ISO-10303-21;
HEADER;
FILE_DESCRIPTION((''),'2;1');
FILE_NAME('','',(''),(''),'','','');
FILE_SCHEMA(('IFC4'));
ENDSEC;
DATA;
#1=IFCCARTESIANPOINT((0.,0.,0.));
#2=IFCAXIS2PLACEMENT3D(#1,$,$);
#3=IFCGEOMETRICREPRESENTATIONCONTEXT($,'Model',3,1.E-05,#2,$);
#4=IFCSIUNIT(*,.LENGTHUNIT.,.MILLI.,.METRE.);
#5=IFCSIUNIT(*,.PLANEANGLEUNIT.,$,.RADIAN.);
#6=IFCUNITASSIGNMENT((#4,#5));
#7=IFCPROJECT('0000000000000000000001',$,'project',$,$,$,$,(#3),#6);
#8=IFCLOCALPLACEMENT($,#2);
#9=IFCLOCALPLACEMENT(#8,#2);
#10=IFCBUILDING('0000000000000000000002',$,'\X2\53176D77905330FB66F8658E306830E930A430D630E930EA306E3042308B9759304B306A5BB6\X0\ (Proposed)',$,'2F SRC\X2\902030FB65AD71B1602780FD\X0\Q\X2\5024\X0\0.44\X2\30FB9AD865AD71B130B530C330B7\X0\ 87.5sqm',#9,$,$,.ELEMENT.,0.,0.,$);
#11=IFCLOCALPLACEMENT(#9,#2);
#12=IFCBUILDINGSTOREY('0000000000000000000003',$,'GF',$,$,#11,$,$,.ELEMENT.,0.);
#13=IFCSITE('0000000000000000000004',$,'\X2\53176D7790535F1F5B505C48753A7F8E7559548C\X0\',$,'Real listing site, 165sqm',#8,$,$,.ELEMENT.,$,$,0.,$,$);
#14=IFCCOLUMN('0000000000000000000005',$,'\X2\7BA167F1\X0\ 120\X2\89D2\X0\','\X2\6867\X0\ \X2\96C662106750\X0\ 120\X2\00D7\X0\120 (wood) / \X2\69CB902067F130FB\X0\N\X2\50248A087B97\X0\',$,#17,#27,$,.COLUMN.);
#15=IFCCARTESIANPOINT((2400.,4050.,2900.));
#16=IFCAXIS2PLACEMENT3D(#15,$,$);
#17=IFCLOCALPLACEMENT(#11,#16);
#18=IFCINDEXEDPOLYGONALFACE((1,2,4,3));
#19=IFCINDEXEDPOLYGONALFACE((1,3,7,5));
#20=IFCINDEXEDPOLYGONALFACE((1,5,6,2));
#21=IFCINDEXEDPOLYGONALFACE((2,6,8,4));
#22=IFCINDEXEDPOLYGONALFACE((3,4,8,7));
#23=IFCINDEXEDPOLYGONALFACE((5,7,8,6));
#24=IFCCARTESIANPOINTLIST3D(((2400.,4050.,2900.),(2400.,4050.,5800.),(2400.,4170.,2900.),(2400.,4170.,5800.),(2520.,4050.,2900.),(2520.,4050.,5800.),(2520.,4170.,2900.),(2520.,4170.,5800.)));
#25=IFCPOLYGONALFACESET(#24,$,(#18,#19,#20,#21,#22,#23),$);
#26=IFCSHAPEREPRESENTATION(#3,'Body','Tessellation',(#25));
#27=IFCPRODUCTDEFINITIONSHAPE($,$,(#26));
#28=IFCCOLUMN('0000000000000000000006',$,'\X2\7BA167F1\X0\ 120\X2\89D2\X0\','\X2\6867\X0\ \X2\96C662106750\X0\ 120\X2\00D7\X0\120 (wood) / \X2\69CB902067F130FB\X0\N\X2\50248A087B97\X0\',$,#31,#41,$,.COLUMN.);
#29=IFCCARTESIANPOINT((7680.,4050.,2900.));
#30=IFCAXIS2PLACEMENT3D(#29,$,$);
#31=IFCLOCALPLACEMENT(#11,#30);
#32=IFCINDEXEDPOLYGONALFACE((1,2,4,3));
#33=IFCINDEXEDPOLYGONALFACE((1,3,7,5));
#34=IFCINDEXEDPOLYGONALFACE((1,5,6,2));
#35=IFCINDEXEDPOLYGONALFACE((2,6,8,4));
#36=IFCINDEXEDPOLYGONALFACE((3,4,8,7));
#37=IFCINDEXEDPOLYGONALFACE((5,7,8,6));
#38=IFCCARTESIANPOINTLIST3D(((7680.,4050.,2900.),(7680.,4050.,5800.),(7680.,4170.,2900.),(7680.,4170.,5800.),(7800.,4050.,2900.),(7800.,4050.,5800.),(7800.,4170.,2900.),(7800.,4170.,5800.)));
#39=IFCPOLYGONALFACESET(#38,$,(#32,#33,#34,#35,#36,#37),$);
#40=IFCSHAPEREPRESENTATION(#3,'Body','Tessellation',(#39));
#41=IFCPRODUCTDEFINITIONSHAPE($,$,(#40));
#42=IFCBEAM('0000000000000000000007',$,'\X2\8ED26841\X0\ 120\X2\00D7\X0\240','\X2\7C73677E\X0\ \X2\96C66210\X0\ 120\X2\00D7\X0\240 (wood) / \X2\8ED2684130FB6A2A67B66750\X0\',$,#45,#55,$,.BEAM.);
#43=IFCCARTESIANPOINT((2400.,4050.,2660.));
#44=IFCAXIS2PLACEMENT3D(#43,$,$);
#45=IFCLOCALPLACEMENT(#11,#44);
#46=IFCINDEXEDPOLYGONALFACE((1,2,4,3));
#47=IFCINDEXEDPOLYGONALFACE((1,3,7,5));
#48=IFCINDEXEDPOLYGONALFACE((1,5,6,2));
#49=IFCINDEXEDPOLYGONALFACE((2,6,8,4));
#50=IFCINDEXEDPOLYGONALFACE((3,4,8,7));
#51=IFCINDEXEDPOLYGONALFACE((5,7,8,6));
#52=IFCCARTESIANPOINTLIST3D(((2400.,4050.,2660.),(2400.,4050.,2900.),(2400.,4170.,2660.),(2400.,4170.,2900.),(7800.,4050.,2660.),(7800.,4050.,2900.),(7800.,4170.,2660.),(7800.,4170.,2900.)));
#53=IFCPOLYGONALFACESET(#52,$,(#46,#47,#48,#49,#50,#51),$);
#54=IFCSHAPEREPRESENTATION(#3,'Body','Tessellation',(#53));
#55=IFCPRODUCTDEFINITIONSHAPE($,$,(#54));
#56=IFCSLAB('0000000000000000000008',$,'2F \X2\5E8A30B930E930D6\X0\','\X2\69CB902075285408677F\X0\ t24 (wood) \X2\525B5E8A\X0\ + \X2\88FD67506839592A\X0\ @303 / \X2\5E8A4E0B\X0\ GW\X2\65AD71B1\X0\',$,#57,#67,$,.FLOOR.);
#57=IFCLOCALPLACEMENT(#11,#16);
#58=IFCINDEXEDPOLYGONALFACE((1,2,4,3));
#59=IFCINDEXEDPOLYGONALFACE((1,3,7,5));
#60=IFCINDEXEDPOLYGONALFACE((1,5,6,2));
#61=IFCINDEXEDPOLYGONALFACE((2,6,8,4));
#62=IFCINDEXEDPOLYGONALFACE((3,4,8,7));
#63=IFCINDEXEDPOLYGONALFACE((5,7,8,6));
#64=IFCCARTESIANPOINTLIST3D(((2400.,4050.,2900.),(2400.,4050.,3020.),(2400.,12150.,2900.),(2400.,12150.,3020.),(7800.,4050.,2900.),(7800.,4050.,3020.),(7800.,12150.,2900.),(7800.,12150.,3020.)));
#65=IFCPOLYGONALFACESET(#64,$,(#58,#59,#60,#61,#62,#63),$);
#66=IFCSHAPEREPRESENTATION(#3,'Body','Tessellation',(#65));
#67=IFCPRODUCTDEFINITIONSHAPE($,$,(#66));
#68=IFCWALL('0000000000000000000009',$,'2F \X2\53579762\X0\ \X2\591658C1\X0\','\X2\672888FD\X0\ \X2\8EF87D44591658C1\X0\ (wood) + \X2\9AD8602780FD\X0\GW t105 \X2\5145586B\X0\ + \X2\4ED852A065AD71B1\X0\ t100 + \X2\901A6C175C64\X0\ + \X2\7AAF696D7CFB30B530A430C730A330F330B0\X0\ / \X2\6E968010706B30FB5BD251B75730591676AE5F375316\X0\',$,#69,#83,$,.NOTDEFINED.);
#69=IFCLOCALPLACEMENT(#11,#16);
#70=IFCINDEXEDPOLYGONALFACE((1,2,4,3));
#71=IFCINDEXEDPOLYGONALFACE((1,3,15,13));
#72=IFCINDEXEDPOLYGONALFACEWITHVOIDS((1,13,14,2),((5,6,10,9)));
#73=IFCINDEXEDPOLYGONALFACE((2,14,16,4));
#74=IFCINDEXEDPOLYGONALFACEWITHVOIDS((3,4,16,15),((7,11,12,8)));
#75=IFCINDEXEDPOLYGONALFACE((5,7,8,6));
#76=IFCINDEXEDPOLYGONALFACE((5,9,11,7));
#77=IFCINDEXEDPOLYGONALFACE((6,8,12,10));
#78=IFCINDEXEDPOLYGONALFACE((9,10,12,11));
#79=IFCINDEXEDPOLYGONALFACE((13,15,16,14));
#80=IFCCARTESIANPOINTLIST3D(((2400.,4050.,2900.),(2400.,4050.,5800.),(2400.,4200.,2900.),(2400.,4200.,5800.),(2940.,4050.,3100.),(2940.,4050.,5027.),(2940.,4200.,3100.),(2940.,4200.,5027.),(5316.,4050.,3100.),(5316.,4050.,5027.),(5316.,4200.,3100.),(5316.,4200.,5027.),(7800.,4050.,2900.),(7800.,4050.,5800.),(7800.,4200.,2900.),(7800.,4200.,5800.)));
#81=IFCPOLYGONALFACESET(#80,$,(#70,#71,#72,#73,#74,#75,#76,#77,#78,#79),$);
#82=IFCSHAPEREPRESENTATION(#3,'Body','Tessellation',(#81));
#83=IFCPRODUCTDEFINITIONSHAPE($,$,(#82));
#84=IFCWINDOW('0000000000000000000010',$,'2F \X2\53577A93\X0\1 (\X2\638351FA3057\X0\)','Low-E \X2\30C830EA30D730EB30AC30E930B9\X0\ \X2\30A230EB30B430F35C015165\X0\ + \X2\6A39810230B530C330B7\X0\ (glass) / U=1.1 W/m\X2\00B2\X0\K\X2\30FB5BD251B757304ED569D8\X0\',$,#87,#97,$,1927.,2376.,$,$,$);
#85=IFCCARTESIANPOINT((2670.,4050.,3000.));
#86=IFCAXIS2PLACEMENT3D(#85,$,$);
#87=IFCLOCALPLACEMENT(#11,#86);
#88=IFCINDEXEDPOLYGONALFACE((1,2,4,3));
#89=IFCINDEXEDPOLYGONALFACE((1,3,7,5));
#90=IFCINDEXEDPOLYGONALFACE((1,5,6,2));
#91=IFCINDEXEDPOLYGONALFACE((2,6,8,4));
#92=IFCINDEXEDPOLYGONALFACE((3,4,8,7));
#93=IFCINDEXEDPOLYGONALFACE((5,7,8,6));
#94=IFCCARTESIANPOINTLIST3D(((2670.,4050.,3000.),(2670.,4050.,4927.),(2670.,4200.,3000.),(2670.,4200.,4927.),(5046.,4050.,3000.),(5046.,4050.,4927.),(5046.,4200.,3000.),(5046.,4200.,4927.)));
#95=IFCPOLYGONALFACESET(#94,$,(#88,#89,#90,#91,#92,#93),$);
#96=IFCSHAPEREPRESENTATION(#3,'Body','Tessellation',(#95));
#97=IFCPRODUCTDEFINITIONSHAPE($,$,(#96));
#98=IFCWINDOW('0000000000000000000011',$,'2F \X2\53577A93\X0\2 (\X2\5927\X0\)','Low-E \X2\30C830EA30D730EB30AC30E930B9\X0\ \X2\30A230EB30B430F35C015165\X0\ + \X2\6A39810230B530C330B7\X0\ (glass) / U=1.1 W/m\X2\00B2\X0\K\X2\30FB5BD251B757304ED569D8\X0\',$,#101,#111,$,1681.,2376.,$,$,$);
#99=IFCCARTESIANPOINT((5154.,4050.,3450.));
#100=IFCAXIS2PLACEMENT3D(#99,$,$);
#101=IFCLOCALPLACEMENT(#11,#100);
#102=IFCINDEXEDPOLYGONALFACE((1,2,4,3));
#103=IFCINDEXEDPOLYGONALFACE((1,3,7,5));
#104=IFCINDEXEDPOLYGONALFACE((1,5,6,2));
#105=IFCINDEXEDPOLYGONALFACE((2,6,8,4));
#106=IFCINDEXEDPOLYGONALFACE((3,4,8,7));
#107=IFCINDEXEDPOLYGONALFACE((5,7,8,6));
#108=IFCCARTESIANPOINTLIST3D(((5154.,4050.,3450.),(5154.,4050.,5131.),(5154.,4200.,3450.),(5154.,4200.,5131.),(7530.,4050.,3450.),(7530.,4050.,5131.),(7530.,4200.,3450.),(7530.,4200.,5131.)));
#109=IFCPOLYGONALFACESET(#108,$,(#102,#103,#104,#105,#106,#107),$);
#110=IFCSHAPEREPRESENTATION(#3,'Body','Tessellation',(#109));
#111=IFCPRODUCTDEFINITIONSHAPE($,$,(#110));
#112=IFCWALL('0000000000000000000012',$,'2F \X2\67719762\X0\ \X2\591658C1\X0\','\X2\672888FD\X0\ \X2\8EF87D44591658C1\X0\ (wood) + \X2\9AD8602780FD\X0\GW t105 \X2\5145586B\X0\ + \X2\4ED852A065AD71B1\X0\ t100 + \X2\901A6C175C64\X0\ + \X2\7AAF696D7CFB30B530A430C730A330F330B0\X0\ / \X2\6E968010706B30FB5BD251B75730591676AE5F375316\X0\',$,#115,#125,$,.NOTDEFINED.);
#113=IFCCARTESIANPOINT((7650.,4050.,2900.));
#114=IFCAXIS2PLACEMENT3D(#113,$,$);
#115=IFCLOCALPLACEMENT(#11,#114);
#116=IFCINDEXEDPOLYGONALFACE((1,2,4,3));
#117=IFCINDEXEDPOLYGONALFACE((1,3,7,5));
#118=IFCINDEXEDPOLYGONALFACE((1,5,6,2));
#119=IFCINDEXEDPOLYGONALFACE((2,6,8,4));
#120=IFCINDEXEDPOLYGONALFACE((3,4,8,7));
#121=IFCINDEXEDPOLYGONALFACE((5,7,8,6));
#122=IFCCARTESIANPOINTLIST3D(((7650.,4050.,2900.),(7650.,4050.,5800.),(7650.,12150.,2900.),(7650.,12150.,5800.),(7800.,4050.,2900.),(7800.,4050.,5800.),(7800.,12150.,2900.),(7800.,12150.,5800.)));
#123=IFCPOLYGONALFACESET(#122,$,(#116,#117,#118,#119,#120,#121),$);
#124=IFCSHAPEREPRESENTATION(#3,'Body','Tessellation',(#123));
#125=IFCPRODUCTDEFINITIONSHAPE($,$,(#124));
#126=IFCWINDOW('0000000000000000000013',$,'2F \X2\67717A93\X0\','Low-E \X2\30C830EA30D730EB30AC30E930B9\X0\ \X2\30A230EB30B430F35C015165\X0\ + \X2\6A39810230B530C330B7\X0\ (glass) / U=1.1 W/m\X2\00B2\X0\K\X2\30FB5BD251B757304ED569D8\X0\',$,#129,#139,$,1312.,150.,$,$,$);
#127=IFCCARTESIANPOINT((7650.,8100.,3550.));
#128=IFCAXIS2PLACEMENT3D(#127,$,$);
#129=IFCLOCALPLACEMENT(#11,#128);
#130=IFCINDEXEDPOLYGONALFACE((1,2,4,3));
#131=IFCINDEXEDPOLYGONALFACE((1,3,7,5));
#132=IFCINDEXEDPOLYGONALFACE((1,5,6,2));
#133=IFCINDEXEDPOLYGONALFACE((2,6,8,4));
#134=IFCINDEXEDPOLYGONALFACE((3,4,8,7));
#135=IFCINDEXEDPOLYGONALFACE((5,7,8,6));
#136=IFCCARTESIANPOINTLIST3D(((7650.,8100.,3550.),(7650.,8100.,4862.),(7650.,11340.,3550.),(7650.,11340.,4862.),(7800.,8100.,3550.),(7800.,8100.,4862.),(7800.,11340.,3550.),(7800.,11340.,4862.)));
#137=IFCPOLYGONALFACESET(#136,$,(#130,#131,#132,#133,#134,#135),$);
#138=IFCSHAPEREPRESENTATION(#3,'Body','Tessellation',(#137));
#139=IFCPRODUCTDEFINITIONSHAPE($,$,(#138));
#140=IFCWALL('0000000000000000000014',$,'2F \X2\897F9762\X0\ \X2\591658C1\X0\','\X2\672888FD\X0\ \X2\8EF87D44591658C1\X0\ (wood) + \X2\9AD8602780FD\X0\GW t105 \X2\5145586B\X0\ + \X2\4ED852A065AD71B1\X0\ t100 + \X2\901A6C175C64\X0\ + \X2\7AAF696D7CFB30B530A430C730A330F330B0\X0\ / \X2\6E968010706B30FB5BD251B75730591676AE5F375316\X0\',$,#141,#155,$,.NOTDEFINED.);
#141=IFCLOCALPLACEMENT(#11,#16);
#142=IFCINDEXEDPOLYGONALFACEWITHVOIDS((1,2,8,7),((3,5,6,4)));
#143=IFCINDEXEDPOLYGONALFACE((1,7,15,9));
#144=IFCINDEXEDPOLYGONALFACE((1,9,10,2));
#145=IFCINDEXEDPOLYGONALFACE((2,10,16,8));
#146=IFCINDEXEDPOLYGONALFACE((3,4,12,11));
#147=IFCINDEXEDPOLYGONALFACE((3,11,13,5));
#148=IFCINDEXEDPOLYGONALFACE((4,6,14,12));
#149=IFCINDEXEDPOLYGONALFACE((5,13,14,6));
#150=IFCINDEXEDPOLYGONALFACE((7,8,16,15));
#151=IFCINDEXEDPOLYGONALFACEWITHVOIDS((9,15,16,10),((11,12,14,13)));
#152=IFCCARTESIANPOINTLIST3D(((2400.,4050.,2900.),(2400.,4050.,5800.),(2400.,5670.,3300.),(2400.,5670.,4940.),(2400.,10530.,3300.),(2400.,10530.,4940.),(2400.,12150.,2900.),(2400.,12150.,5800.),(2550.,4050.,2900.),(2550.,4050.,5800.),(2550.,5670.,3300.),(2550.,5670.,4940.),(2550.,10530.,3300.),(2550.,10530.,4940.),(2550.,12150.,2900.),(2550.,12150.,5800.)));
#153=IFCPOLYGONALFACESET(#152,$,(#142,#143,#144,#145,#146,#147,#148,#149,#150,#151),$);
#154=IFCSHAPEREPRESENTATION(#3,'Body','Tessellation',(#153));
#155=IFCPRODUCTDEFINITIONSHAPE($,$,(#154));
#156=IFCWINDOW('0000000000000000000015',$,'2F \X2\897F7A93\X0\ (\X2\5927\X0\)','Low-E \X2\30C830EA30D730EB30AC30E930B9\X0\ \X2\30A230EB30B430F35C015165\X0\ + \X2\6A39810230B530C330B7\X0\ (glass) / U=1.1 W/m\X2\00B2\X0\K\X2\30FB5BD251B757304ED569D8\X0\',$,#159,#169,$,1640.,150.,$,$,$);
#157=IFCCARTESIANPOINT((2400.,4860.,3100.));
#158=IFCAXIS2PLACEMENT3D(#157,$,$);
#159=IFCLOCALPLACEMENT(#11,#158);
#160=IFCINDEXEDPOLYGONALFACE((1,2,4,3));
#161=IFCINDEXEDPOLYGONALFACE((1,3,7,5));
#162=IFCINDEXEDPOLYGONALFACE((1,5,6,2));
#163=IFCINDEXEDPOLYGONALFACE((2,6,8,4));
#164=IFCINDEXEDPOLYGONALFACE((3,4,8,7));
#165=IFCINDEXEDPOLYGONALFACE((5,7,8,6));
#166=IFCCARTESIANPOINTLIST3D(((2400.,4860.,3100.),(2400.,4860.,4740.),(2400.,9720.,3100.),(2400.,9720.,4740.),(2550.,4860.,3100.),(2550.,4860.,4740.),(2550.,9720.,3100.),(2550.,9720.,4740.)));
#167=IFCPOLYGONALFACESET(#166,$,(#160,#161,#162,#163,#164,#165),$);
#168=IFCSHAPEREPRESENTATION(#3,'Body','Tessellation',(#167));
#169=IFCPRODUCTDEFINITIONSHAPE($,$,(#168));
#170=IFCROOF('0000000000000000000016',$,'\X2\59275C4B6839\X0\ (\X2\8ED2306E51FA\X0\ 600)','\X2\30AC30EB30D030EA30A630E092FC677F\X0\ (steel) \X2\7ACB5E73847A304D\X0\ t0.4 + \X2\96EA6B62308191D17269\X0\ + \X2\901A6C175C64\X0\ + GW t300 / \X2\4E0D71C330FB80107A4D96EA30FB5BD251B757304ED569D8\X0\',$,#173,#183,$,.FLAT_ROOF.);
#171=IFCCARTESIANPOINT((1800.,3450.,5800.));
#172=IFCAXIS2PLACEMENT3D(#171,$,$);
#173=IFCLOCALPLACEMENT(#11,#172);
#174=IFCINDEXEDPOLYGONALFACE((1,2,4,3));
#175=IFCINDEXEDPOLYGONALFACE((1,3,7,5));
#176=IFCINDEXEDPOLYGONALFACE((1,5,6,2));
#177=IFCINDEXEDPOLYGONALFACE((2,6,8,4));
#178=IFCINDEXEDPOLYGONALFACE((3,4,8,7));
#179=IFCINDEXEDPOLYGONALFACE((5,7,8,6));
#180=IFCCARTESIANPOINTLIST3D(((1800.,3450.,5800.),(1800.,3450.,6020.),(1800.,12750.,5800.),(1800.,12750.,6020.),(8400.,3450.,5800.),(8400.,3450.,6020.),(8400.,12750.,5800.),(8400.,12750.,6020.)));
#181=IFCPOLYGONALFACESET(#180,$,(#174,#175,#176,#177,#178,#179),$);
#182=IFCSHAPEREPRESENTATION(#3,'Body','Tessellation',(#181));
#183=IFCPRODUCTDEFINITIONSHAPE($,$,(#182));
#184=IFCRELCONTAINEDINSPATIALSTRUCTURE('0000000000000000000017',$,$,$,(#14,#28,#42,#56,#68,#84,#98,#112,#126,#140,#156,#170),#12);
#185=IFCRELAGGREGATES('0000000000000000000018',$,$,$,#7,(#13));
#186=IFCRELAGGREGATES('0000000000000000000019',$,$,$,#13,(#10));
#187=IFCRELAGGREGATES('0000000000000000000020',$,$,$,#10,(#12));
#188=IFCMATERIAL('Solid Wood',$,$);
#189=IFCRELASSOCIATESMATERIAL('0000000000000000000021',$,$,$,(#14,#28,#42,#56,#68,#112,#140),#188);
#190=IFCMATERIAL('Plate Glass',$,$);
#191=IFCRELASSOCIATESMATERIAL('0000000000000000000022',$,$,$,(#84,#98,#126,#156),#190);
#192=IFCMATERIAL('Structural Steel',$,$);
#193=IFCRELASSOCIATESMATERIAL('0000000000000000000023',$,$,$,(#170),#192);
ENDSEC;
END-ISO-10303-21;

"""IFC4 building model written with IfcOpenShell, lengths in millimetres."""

from ifc_helpers import new_model, si_unit, frame, frame_2d, origin, place, context, project, spatial, rectangle, extrude, material, element, fill, save


model = new_model("IFC4")

# Units and contexts
model_context = context("Model", 3, precision=1e-05, world=origin())
ifc_project = project(units=[si_unit("LENGTHUNIT", "METRE", prefix="MILLI"), si_unit("PLANEANGLEUNIT", "RADIAN")], contexts=[model_context])

# Site, building, storey
site_placement = place(None, origin())
site = spatial("IfcSite", under=ifc_project, at=site_placement, Name="北海道弟子屈町美留和", ObjectType="Real listing site, 165sqm", CompositionType="ELEMENT", RefElevation=0.0)
building_placement = place(site_placement, origin())
building = spatial("IfcBuilding", under=site, at=building_placement, Name="北海道・書斎とライブラリのある静かな家 (Proposed)", ObjectType="2F SRC造・断熱性能Q値0.44・高断熱サッシ 87.5sqm", CompositionType="ELEMENT", ElevationOfRefHeight=0.0, ElevationOfTerrain=0.0)
storey_placement = place(building_placement, origin())
storey = spatial("IfcBuildingStorey", under=building, at=storey_placement, Name="GF", CompositionType="ELEMENT", Elevation=0.0)

# Columns
ifc_material_1 = material(Name="Solid Wood")
column_1_placement = place(storey_placement, frame((2400.0, 4050.0, 2900.0)))
element("IfcColumn", 1, at=column_1_placement, inside=storey, material=ifc_material_1, Name="管柱 120角", Description="桧 集成材 120×120 (wood) / 構造柱・N値計算", PredefinedType="COLUMN", context=model_context, shape_type="SweptSolid", body=[
    extrude(rectangle(XDim=120.0, YDim=120.0, at=frame_2d((60.0, 60.0))), frame((2400.0, 4050.0, 2900.0)), (0.0, 0.0, 1.0), 2900.0),
])
column_2_placement = place(storey_placement, frame((7680.0, 4050.0, 2900.0)))
element("IfcColumn", 2, at=column_2_placement, inside=storey, material=ifc_material_1, Name="管柱 120角", Description="桧 集成材 120×120 (wood) / 構造柱・N値計算", PredefinedType="COLUMN", context=model_context, shape_type="SweptSolid", body=[
    extrude(rectangle(XDim=120.0, YDim=120.0, at=frame_2d((60.0, 60.0))), frame((7680.0, 4050.0, 2900.0)), (0.0, 0.0, 1.0), 2900.0),
])

# Beam
beam_1_placement = place(storey_placement, frame((2400.0, 4050.0, 2660.0)))
element("IfcBeam", 3, at=beam_1_placement, inside=storey, material=ifc_material_1, Name="軒桁 120×240", Description="米松 集成 120×240 (wood) / 軒桁・横架材", PredefinedType="BEAM", context=model_context, shape_type="SweptSolid", body=[
    extrude(rectangle(XDim=5400.0, YDim=120.0, at=frame_2d((2700.0, 60.0))), frame((2400.0, 4050.0, 2660.0)), (0.0, 0.0, 1.0), 240.0),
])

# Slab
slab_placement = place(storey_placement, frame((2400.0, 4050.0, 2900.0)))
element("IfcSlab", 4, at=slab_placement, inside=storey, material=ifc_material_1, Name="2F 床スラブ", Description="構造用合板 t24 (wood) 剛床 + 製材根太 @303 / 床下 GW断熱", PredefinedType="FLOOR", context=model_context, shape_type="SweptSolid", body=[
    extrude(rectangle(XDim=5400.0, YDim=8100.0, at=frame_2d((2700.0, 4050.0))), frame((2400.0, 4050.0, 2900.0)), (0.0, 0.0, 1.0), 120.0),
])

# Wall, openings, windows
wall_1_placement = place(storey_placement, frame((2400.0, 4050.0, 2900.0)))
wall_1 = element("IfcWall", 5, at=wall_1_placement, inside=storey, material=ifc_material_1, Name="2F 南面 外壁", Description="木製 軸組外壁 (wood) + 高性能GW t105 充填 + 付加断熱 t100 + 通気層 + 窯業系サイディング / 準耐火・寒冷地外皮強化", PredefinedType="NOTDEFINED", context=model_context, shape_type="SweptSolid", body=[
    extrude(rectangle(XDim=5400.0, YDim=150.0, at=frame_2d((2700.0, 75.0))), frame((2400.0, 4050.0, 2900.0)), (0.0, 0.0, 1.0), 2900.0),
])
opening_1_placement = place(storey_placement, frame((2670.0, 4050.0, 3000.0)))
opening_1 = element("IfcOpeningElement", 6, at=opening_1_placement, cuts=wall_1, PredefinedType="NOTDEFINED", context=model_context, shape_type="SweptSolid", body=[
    extrude(rectangle(XDim=2376.0, YDim=150.0, at=frame_2d((1188.0, 75.0))), frame((2670.0, 4050.0, 3000.0)), (0.0, 0.0, 1.0), 1927.0),
])
opening_2_placement = place(storey_placement, frame((5154.0, 4050.0, 3450.0)))
opening_2 = element("IfcOpeningElement", 7, at=opening_2_placement, cuts=wall_1, PredefinedType="NOTDEFINED", context=model_context, shape_type="SweptSolid", body=[
    extrude(rectangle(XDim=2376.0, YDim=150.0, at=frame_2d((1188.0, 75.0))), frame((5154.0, 4050.0, 3450.0)), (0.0, 0.0, 1.0), 1681.0),
])
ifc_material_2 = material(Name="Plate Glass")
window_1_placement = place(storey_placement, frame((2670.0, 4050.0, 3000.0)))
window_1 = element("IfcWindow", 8, at=window_1_placement, inside=storey, material=ifc_material_2, Name="2F 南窓1 (掃出し)", Description="Low-E トリプルガラス アルゴン封入 + 樹脂サッシ (glass) / U=1.1 W/m²K・寒冷地仕様", OverallHeight=1927.0, OverallWidth=2376.0, context=model_context, shape_type="SweptSolid", body=[
    extrude(rectangle(XDim=2376.0, YDim=150.0, at=frame_2d((1188.0, 75.0))), frame((2670.0, 4050.0, 3000.0)), (0.0, 0.0, 1.0), 1927.0),
])
fill(opening_1, window_1)
window_2_placement = place(storey_placement, frame((5154.0, 4050.0, 3450.0)))
window_2 = element("IfcWindow", 9, at=window_2_placement, inside=storey, material=ifc_material_2, Name="2F 南窓2 (大)", Description="Low-E トリプルガラス アルゴン封入 + 樹脂サッシ (glass) / U=1.1 W/m²K・寒冷地仕様", OverallHeight=1681.0, OverallWidth=2376.0, context=model_context, shape_type="SweptSolid", body=[
    extrude(rectangle(XDim=2376.0, YDim=150.0, at=frame_2d((1188.0, 75.0))), frame((5154.0, 4050.0, 3450.0)), (0.0, 0.0, 1.0), 1681.0),
])
fill(opening_2, window_2)

# Walls, openings, windows
wall_2_placement = place(storey_placement, frame((7650.0, 4050.0, 2900.0)))
wall_2 = element("IfcWall", 10, at=wall_2_placement, inside=storey, material=ifc_material_1, Name="2F 東面 外壁", Description="木製 軸組外壁 (wood) + 高性能GW t105 充填 + 付加断熱 t100 + 通気層 + 窯業系サイディング / 準耐火・寒冷地外皮強化", PredefinedType="NOTDEFINED", context=model_context, shape_type="SweptSolid", body=[
    extrude(rectangle(XDim=150.0, YDim=8100.0, at=frame_2d((75.0, 4050.0))), frame((7650.0, 4050.0, 2900.0)), (0.0, 0.0, 1.0), 2900.0),
])
opening_3_placement = place(storey_placement, frame((7650.0, 8100.0, 3550.0)))
opening_3 = element("IfcOpeningElement", 11, at=opening_3_placement, cuts=wall_2, PredefinedType="NOTDEFINED", context=model_context, shape_type="SweptSolid", body=[
    extrude(rectangle(XDim=150.0, YDim=3240.0, at=frame_2d((75.0, 1620.0))), frame((7650.0, 8100.0, 3550.0)), (0.0, 0.0, 1.0), 1312.0),
])
window_3_placement = place(storey_placement, frame((7650.0, 8100.0, 3550.0)))
window_3 = element("IfcWindow", 12, at=window_3_placement, inside=storey, material=ifc_material_2, Name="2F 東窓", Description="Low-E トリプルガラス アルゴン封入 + 樹脂サッシ (glass) / U=1.1 W/m²K・寒冷地仕様", OverallHeight=1312.0, OverallWidth=150.0, context=model_context, shape_type="SweptSolid", body=[
    extrude(rectangle(XDim=150.0, YDim=3240.0, at=frame_2d((75.0, 1620.0))), frame((7650.0, 8100.0, 3550.0)), (0.0, 0.0, 1.0), 1312.0),
])
fill(opening_3, window_3)
wall_3_placement = place(storey_placement, frame((2400.0, 4050.0, 2900.0)))
wall_3 = element("IfcWall", 13, at=wall_3_placement, inside=storey, material=ifc_material_1, Name="2F 西面 外壁", Description="木製 軸組外壁 (wood) + 高性能GW t105 充填 + 付加断熱 t100 + 通気層 + 窯業系サイディング / 準耐火・寒冷地外皮強化", PredefinedType="NOTDEFINED", context=model_context, shape_type="SweptSolid", body=[
    extrude(rectangle(XDim=150.0, YDim=8100.0, at=frame_2d((75.0, 4050.0))), frame((2400.0, 4050.0, 2900.0)), (0.0, 0.0, 1.0), 2900.0),
])
opening_4_placement = place(storey_placement, frame((2400.0, 4860.0, 3100.0)))
opening_4 = element("IfcOpeningElement", 14, at=opening_4_placement, cuts=wall_3, PredefinedType="NOTDEFINED", context=model_context, shape_type="SweptSolid", body=[
    extrude(rectangle(XDim=150.0, YDim=4860.0, at=frame_2d((75.0, 2430.0))), frame((2400.0, 4860.0, 3100.0)), (0.0, 0.0, 1.0), 1640.0),
])
window_4_placement = place(storey_placement, frame((2400.0, 4860.0, 3100.0)))
window_4 = element("IfcWindow", 15, at=window_4_placement, inside=storey, material=ifc_material_2, Name="2F 西窓 (大)", Description="Low-E トリプルガラス アルゴン封入 + 樹脂サッシ (glass) / U=1.1 W/m²K・寒冷地仕様", OverallHeight=1640.0, OverallWidth=150.0, context=model_context, shape_type="SweptSolid", body=[
    extrude(rectangle(XDim=150.0, YDim=4860.0, at=frame_2d((75.0, 2430.0))), frame((2400.0, 4860.0, 3100.0)), (0.0, 0.0, 1.0), 1640.0),
])
fill(opening_4, window_4)

# Roof
ifc_material_3 = material(Name="Structural Steel")
roof_placement = place(storey_placement, frame((1800.0, 3450.0, 5800.0)))
element("IfcRoof", 16, at=roof_placement, inside=storey, material=ifc_material_3, Name="大屋根 (軒の出 600)", Description="ガルバリウム鋼板 (steel) 立平葺き t0.4 + 雪止め金物 + 通気層 + GW t300 / 不燃・耐積雪・寒冷地仕様", PredefinedType="FLAT_ROOF", context=model_context, shape_type="SweptSolid", body=[
    extrude(rectangle(XDim=6600.0, YDim=9300.0, at=frame_2d((3300.0, 4650.0))), frame((1800.0, 3450.0, 5800.0)), (0.0, 0.0, 1.0), 220.0),
])

save(model, "model.ifc")
